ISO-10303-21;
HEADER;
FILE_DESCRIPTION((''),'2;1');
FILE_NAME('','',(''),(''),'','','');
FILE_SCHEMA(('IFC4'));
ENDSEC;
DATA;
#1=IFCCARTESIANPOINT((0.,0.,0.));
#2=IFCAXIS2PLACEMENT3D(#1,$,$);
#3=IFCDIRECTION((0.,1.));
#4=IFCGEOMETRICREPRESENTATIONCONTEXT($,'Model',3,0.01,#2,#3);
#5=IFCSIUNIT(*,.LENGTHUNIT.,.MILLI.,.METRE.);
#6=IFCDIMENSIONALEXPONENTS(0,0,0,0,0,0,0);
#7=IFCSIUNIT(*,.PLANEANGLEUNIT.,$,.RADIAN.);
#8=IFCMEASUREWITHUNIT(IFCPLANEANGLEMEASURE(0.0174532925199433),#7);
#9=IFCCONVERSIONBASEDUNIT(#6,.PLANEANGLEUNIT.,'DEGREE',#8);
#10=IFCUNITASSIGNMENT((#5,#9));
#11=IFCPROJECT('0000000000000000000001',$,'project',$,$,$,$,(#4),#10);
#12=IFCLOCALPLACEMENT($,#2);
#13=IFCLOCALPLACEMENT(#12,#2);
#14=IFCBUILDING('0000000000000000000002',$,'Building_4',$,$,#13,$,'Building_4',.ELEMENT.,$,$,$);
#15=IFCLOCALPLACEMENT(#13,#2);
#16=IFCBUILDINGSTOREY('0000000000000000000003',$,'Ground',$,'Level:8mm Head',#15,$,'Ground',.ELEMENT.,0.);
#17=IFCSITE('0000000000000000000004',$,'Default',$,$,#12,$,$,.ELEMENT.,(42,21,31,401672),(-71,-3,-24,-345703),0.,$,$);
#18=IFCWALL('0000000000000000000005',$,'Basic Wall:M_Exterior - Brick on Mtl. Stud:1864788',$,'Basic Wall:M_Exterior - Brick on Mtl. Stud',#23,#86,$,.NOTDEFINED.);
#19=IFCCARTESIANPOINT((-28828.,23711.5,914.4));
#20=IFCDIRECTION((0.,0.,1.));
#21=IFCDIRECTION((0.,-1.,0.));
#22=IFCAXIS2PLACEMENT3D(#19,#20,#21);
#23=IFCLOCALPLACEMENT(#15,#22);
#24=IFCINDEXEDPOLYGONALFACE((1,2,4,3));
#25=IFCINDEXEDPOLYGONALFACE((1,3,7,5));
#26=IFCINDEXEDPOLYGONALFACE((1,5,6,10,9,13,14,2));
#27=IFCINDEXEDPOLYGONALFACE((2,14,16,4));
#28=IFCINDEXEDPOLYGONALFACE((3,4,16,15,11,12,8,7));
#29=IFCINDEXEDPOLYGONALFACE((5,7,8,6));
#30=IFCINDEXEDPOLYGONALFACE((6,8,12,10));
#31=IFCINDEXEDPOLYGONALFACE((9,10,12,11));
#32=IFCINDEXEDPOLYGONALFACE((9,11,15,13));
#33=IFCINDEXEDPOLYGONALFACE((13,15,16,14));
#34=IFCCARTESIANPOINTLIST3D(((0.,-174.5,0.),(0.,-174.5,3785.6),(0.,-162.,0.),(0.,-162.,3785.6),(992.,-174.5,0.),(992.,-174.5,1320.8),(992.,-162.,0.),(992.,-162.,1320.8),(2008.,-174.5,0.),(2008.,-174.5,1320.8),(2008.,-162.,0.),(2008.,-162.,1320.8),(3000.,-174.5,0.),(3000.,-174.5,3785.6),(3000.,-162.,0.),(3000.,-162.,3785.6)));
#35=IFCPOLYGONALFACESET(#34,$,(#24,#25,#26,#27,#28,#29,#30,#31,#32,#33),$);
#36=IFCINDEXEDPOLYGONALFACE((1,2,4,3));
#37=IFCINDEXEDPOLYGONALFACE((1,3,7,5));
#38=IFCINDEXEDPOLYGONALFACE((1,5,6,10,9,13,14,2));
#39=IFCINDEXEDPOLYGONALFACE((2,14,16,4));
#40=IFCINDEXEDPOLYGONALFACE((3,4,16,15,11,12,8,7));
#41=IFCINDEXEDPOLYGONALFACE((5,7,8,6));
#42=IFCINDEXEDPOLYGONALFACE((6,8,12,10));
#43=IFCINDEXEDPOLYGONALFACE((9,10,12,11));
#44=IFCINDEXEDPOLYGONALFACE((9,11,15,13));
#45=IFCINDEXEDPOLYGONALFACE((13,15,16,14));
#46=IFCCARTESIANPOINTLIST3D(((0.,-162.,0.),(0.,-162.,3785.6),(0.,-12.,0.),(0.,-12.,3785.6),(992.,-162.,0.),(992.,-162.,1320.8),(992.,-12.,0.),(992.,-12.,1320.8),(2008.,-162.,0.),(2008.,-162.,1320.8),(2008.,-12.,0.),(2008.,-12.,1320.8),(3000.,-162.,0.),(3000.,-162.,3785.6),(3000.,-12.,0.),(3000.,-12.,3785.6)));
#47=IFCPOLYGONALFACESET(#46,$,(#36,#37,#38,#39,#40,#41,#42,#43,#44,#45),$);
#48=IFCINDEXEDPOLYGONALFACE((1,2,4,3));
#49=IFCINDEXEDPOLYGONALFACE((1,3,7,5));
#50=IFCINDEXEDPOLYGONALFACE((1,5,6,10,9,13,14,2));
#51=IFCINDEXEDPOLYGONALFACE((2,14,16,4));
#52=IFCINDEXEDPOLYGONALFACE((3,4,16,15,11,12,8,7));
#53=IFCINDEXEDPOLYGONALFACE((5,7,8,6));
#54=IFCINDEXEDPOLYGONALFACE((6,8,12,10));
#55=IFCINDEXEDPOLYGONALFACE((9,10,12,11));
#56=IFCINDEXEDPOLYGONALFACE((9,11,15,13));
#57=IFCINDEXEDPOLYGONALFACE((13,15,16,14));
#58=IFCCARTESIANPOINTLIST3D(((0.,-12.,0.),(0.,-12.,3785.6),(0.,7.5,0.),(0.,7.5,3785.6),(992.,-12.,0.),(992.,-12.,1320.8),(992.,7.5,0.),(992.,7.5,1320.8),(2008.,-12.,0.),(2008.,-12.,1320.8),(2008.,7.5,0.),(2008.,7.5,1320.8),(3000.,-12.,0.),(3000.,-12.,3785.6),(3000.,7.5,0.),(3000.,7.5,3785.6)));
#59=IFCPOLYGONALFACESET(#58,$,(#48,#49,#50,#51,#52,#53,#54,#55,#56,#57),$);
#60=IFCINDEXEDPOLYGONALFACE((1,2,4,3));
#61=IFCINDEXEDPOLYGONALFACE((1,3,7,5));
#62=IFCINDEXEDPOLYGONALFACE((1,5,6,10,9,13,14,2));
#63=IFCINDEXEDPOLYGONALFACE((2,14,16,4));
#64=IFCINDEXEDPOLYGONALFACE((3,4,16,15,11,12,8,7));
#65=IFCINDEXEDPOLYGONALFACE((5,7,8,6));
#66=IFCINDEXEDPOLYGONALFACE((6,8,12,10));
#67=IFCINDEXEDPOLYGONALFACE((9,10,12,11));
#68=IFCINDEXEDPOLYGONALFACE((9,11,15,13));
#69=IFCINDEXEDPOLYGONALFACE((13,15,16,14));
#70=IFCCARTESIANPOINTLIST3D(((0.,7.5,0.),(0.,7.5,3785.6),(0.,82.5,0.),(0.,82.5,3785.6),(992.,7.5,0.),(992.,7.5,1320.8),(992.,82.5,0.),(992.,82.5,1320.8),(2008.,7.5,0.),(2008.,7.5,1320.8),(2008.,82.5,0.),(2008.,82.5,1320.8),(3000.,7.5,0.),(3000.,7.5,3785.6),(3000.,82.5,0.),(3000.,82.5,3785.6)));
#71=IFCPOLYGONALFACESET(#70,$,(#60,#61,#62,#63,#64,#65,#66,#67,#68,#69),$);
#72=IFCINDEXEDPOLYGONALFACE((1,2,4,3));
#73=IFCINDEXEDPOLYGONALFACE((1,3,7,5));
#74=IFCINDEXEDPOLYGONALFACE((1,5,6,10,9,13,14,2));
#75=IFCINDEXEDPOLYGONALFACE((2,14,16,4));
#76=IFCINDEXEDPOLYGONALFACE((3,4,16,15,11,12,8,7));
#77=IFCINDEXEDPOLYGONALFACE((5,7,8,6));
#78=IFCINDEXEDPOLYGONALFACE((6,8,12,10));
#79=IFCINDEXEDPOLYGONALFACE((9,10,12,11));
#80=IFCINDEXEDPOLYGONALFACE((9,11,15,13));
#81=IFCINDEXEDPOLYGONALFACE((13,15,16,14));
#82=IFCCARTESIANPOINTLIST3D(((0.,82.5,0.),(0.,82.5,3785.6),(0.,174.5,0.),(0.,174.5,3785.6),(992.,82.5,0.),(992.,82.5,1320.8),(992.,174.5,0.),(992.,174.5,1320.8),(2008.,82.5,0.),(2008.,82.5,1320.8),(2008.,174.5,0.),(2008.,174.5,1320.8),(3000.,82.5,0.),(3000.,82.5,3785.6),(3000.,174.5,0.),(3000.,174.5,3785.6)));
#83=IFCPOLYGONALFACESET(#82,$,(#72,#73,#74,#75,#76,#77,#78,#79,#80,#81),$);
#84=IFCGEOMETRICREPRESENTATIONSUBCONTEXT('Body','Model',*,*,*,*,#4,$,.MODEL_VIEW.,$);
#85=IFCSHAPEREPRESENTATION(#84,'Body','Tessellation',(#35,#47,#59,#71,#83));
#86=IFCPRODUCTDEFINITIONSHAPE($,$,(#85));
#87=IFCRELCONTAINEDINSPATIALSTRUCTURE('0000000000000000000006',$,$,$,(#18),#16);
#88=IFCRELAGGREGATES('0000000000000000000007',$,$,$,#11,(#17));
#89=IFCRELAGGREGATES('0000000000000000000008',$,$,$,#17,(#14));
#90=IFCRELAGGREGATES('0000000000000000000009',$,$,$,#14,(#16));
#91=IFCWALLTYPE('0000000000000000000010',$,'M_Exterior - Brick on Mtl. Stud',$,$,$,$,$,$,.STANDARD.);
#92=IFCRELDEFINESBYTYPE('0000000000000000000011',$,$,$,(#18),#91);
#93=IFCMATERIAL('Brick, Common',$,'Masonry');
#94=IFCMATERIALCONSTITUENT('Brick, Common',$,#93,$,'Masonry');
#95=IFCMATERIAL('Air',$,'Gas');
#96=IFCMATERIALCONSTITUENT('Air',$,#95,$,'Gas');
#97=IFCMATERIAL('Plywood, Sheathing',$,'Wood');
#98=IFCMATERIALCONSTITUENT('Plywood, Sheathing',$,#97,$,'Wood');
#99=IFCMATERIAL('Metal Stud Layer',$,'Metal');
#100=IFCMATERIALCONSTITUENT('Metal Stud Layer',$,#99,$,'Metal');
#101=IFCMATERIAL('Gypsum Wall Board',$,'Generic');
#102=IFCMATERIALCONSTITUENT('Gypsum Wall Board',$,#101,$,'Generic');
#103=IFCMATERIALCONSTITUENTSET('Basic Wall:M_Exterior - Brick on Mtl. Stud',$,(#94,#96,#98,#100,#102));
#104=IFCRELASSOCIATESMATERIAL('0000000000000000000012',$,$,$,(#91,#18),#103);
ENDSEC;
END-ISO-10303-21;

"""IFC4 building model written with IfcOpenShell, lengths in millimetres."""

from ifc_helpers import new_model, entity, si_unit, converted_unit, direction, frame, origin, place, context, subcontext, project, spatial, indexed_curve, outline, extrude, material, constituent, constituent_set, type_object, element, save


model = new_model("IFC4")

# Units and contexts
model_context = context("Model", 3, precision=0.01, world=origin(), true_north=direction((0.0, 1.0)))
body_context = subcontext(model_context, "Body", "Model", "MODEL_VIEW")
ifc_project = project(units=[si_unit("LENGTHUNIT", "METRE", prefix="MILLI"), converted_unit("PLANEANGLEUNIT", "DEGREE", entity("IfcPlaneAngleMeasure", 0.0174532925199433), si_unit("PLANEANGLEUNIT", "RADIAN"), dimensions=[0, 0, 0, 0, 0, 0, 0])], contexts=[model_context])

# Site, building, storey
site_placement = place(None, origin())
site = spatial("IfcSite", under=ifc_project, at=site_placement, Name="Default", CompositionType="ELEMENT", RefLatitude=(42, 21, 31, 401672), RefLongitude=(-71, -3, -24, -345703), RefElevation=0.0)
building_placement = place(site_placement, origin())
building = spatial("IfcBuilding", under=site, at=building_placement, Name="Building_4", LongName="Building_4", CompositionType="ELEMENT")
storey_placement = place(building_placement, origin())
storey = spatial("IfcBuildingStorey", under=building, at=storey_placement, Name="Ground", ObjectType="Level:8mm Head", LongName="Ground", CompositionType="ELEMENT", Elevation=0.0)

# Shared definitions
ifc_material_1 = material(Name="Brick, Common", Category="Masonry")
ifc_constituent_1 = constituent(ifc_material_1, Name="Brick, Common", Category="Masonry")
ifc_material_2 = material(Name="Air", Category="Gas")
ifc_constituent_2 = constituent(ifc_material_2, Name="Air", Category="Gas")
ifc_material_3 = material(Name="Plywood, Sheathing", Category="Wood")
ifc_constituent_3 = constituent(ifc_material_3, Name="Plywood, Sheathing", Category="Wood")
ifc_material_4 = material(Name="Metal Stud Layer", Category="Metal")
ifc_constituent_4 = constituent(ifc_material_4, Name="Metal Stud Layer", Category="Metal")
ifc_material_5 = material(Name="Gypsum Wall Board", Category="Generic")
ifc_constituent_5 = constituent(ifc_material_5, Name="Gypsum Wall Board", Category="Generic")
ifc_constituent_set_1 = constituent_set(constituents=[ifc_constituent_1, ifc_constituent_2, ifc_constituent_3, ifc_constituent_4, ifc_constituent_5], Name="Basic Wall:M_Exterior - Brick on Mtl. Stud")
wall_type_1 = type_object("IfcWallType", Name="M_Exterior - Brick on Mtl. Stud", PredefinedType="STANDARD", material=ifc_constituent_set_1)

# Wall, opening
wall_1_placement = place(storey_placement, frame((-28828.0, 23711.5, 914.4), z_axis=(0.0, 0.0, 1.0), x_axis=(0.0, -1.0, 0.0)))
wall_1 = element("IfcWall", 1, at=wall_1_placement, inside=storey, type_object=wall_type_1, material=ifc_constituent_set_1, Name="Basic Wall:M_Exterior - Brick on Mtl. Stud:1864788", ObjectType="Basic Wall:M_Exterior - Brick on Mtl. Stud", PredefinedType="NOTDEFINED", context=body_context, shape_type="SweptSolid", body=[
    extrude(outline(indexed_curve([(-1500.0, -1276.6), (-508.0, -1276.6), (-508.0, 44.2), (508.0, 44.2), (508.0, -1276.6), (1500.0, -1276.6), (1500.0, 2509.0), (-1500.0, 2509.0), (-1500.0, -1276.6)], self_intersect=False)), frame((1500.0, -174.5, 1276.6), z_axis=(0.0, 1.0, 0.0), x_axis=(-1.0, 0.0, 0.0)), (0.0, 0.0, 1.0), 12.5),
    extrude(outline(indexed_curve([(-1276.6, -508.0), (-1276.6, -1500.0), (2509.0, -1500.0), (2509.0, 1500.0), (-1276.6, 1500.0), (-1276.6, 508.0), (44.2, 508.0), (44.2, -508.0), (-1276.6, -508.0)], self_intersect=False)), frame((1500.0, -162.0, 1276.6), z_axis=(0.0, -1.0, 0.0), x_axis=(0.0, 0.0, 1.0)), (0.0, 0.0, -1.0), 150.0),
    extrude(outline(indexed_curve([(-1276.6, -508.0), (-1276.6, -1500.0), (2509.0, -1500.0), (2509.0, 1500.0), (-1276.6, 1500.0), (-1276.6, 508.0), (44.2, 508.0), (44.2, -508.0), (-1276.6, -508.0)], self_intersect=False)), frame((1500.0, -12.0, 1276.6), z_axis=(0.0, -1.0, 0.0), x_axis=(0.0, 0.0, 1.0)), (0.0, 0.0, -1.0), 19.5),
    extrude(outline(indexed_curve([(-1276.6, -508.0), (-1276.6, -1500.0), (2509.0, -1500.0), (2509.0, 1500.0), (-1276.6, 1500.0), (-1276.6, 508.0), (44.2, 508.0), (44.2, -508.0), (-1276.6, -508.0)], self_intersect=False)), frame((1500.0, 7.5, 1276.6), z_axis=(0.0, -1.0, 0.0), x_axis=(0.0, 0.0, 1.0)), (0.0, 0.0, -1.0), 75.0),
    extrude(outline(indexed_curve([(-1276.6, -508.0), (-1276.6, -1500.0), (2509.0, -1500.0), (2509.0, 1500.0), (-1276.6, 1500.0), (-1276.6, 508.0), (44.2, 508.0), (44.2, -508.0), (-1276.6, -508.0)], self_intersect=False)), frame((1500.0, 82.5, 1276.6), z_axis=(0.0, -1.0, 0.0), x_axis=(0.0, 0.0, 1.0)), (0.0, 0.0, -1.0), 92.0),
])
opening_1_placement = place(wall_1_placement, frame((992.0, -174.5, -914.4)))
element("IfcOpeningElement", 2, at=opening_1_placement, cuts=wall_1, PredefinedType="OPENING", context=body_context, shape_type="SweptSolid", body=[
    extrude(outline(indexed_curve([(0.0, 1016.0), (0.0, 0.0), (2235.2, 0.0), (2235.2, 1016.0), (0.0, 1016.0)], self_intersect=False)), frame((0.0, 0.0, 0.0), z_axis=(0.0, 1.0, 0.0), x_axis=(0.0, 0.0, 1.0)), (0.0, 0.0, 1.0), 349.0),
])

save(model, "model.ifc")
